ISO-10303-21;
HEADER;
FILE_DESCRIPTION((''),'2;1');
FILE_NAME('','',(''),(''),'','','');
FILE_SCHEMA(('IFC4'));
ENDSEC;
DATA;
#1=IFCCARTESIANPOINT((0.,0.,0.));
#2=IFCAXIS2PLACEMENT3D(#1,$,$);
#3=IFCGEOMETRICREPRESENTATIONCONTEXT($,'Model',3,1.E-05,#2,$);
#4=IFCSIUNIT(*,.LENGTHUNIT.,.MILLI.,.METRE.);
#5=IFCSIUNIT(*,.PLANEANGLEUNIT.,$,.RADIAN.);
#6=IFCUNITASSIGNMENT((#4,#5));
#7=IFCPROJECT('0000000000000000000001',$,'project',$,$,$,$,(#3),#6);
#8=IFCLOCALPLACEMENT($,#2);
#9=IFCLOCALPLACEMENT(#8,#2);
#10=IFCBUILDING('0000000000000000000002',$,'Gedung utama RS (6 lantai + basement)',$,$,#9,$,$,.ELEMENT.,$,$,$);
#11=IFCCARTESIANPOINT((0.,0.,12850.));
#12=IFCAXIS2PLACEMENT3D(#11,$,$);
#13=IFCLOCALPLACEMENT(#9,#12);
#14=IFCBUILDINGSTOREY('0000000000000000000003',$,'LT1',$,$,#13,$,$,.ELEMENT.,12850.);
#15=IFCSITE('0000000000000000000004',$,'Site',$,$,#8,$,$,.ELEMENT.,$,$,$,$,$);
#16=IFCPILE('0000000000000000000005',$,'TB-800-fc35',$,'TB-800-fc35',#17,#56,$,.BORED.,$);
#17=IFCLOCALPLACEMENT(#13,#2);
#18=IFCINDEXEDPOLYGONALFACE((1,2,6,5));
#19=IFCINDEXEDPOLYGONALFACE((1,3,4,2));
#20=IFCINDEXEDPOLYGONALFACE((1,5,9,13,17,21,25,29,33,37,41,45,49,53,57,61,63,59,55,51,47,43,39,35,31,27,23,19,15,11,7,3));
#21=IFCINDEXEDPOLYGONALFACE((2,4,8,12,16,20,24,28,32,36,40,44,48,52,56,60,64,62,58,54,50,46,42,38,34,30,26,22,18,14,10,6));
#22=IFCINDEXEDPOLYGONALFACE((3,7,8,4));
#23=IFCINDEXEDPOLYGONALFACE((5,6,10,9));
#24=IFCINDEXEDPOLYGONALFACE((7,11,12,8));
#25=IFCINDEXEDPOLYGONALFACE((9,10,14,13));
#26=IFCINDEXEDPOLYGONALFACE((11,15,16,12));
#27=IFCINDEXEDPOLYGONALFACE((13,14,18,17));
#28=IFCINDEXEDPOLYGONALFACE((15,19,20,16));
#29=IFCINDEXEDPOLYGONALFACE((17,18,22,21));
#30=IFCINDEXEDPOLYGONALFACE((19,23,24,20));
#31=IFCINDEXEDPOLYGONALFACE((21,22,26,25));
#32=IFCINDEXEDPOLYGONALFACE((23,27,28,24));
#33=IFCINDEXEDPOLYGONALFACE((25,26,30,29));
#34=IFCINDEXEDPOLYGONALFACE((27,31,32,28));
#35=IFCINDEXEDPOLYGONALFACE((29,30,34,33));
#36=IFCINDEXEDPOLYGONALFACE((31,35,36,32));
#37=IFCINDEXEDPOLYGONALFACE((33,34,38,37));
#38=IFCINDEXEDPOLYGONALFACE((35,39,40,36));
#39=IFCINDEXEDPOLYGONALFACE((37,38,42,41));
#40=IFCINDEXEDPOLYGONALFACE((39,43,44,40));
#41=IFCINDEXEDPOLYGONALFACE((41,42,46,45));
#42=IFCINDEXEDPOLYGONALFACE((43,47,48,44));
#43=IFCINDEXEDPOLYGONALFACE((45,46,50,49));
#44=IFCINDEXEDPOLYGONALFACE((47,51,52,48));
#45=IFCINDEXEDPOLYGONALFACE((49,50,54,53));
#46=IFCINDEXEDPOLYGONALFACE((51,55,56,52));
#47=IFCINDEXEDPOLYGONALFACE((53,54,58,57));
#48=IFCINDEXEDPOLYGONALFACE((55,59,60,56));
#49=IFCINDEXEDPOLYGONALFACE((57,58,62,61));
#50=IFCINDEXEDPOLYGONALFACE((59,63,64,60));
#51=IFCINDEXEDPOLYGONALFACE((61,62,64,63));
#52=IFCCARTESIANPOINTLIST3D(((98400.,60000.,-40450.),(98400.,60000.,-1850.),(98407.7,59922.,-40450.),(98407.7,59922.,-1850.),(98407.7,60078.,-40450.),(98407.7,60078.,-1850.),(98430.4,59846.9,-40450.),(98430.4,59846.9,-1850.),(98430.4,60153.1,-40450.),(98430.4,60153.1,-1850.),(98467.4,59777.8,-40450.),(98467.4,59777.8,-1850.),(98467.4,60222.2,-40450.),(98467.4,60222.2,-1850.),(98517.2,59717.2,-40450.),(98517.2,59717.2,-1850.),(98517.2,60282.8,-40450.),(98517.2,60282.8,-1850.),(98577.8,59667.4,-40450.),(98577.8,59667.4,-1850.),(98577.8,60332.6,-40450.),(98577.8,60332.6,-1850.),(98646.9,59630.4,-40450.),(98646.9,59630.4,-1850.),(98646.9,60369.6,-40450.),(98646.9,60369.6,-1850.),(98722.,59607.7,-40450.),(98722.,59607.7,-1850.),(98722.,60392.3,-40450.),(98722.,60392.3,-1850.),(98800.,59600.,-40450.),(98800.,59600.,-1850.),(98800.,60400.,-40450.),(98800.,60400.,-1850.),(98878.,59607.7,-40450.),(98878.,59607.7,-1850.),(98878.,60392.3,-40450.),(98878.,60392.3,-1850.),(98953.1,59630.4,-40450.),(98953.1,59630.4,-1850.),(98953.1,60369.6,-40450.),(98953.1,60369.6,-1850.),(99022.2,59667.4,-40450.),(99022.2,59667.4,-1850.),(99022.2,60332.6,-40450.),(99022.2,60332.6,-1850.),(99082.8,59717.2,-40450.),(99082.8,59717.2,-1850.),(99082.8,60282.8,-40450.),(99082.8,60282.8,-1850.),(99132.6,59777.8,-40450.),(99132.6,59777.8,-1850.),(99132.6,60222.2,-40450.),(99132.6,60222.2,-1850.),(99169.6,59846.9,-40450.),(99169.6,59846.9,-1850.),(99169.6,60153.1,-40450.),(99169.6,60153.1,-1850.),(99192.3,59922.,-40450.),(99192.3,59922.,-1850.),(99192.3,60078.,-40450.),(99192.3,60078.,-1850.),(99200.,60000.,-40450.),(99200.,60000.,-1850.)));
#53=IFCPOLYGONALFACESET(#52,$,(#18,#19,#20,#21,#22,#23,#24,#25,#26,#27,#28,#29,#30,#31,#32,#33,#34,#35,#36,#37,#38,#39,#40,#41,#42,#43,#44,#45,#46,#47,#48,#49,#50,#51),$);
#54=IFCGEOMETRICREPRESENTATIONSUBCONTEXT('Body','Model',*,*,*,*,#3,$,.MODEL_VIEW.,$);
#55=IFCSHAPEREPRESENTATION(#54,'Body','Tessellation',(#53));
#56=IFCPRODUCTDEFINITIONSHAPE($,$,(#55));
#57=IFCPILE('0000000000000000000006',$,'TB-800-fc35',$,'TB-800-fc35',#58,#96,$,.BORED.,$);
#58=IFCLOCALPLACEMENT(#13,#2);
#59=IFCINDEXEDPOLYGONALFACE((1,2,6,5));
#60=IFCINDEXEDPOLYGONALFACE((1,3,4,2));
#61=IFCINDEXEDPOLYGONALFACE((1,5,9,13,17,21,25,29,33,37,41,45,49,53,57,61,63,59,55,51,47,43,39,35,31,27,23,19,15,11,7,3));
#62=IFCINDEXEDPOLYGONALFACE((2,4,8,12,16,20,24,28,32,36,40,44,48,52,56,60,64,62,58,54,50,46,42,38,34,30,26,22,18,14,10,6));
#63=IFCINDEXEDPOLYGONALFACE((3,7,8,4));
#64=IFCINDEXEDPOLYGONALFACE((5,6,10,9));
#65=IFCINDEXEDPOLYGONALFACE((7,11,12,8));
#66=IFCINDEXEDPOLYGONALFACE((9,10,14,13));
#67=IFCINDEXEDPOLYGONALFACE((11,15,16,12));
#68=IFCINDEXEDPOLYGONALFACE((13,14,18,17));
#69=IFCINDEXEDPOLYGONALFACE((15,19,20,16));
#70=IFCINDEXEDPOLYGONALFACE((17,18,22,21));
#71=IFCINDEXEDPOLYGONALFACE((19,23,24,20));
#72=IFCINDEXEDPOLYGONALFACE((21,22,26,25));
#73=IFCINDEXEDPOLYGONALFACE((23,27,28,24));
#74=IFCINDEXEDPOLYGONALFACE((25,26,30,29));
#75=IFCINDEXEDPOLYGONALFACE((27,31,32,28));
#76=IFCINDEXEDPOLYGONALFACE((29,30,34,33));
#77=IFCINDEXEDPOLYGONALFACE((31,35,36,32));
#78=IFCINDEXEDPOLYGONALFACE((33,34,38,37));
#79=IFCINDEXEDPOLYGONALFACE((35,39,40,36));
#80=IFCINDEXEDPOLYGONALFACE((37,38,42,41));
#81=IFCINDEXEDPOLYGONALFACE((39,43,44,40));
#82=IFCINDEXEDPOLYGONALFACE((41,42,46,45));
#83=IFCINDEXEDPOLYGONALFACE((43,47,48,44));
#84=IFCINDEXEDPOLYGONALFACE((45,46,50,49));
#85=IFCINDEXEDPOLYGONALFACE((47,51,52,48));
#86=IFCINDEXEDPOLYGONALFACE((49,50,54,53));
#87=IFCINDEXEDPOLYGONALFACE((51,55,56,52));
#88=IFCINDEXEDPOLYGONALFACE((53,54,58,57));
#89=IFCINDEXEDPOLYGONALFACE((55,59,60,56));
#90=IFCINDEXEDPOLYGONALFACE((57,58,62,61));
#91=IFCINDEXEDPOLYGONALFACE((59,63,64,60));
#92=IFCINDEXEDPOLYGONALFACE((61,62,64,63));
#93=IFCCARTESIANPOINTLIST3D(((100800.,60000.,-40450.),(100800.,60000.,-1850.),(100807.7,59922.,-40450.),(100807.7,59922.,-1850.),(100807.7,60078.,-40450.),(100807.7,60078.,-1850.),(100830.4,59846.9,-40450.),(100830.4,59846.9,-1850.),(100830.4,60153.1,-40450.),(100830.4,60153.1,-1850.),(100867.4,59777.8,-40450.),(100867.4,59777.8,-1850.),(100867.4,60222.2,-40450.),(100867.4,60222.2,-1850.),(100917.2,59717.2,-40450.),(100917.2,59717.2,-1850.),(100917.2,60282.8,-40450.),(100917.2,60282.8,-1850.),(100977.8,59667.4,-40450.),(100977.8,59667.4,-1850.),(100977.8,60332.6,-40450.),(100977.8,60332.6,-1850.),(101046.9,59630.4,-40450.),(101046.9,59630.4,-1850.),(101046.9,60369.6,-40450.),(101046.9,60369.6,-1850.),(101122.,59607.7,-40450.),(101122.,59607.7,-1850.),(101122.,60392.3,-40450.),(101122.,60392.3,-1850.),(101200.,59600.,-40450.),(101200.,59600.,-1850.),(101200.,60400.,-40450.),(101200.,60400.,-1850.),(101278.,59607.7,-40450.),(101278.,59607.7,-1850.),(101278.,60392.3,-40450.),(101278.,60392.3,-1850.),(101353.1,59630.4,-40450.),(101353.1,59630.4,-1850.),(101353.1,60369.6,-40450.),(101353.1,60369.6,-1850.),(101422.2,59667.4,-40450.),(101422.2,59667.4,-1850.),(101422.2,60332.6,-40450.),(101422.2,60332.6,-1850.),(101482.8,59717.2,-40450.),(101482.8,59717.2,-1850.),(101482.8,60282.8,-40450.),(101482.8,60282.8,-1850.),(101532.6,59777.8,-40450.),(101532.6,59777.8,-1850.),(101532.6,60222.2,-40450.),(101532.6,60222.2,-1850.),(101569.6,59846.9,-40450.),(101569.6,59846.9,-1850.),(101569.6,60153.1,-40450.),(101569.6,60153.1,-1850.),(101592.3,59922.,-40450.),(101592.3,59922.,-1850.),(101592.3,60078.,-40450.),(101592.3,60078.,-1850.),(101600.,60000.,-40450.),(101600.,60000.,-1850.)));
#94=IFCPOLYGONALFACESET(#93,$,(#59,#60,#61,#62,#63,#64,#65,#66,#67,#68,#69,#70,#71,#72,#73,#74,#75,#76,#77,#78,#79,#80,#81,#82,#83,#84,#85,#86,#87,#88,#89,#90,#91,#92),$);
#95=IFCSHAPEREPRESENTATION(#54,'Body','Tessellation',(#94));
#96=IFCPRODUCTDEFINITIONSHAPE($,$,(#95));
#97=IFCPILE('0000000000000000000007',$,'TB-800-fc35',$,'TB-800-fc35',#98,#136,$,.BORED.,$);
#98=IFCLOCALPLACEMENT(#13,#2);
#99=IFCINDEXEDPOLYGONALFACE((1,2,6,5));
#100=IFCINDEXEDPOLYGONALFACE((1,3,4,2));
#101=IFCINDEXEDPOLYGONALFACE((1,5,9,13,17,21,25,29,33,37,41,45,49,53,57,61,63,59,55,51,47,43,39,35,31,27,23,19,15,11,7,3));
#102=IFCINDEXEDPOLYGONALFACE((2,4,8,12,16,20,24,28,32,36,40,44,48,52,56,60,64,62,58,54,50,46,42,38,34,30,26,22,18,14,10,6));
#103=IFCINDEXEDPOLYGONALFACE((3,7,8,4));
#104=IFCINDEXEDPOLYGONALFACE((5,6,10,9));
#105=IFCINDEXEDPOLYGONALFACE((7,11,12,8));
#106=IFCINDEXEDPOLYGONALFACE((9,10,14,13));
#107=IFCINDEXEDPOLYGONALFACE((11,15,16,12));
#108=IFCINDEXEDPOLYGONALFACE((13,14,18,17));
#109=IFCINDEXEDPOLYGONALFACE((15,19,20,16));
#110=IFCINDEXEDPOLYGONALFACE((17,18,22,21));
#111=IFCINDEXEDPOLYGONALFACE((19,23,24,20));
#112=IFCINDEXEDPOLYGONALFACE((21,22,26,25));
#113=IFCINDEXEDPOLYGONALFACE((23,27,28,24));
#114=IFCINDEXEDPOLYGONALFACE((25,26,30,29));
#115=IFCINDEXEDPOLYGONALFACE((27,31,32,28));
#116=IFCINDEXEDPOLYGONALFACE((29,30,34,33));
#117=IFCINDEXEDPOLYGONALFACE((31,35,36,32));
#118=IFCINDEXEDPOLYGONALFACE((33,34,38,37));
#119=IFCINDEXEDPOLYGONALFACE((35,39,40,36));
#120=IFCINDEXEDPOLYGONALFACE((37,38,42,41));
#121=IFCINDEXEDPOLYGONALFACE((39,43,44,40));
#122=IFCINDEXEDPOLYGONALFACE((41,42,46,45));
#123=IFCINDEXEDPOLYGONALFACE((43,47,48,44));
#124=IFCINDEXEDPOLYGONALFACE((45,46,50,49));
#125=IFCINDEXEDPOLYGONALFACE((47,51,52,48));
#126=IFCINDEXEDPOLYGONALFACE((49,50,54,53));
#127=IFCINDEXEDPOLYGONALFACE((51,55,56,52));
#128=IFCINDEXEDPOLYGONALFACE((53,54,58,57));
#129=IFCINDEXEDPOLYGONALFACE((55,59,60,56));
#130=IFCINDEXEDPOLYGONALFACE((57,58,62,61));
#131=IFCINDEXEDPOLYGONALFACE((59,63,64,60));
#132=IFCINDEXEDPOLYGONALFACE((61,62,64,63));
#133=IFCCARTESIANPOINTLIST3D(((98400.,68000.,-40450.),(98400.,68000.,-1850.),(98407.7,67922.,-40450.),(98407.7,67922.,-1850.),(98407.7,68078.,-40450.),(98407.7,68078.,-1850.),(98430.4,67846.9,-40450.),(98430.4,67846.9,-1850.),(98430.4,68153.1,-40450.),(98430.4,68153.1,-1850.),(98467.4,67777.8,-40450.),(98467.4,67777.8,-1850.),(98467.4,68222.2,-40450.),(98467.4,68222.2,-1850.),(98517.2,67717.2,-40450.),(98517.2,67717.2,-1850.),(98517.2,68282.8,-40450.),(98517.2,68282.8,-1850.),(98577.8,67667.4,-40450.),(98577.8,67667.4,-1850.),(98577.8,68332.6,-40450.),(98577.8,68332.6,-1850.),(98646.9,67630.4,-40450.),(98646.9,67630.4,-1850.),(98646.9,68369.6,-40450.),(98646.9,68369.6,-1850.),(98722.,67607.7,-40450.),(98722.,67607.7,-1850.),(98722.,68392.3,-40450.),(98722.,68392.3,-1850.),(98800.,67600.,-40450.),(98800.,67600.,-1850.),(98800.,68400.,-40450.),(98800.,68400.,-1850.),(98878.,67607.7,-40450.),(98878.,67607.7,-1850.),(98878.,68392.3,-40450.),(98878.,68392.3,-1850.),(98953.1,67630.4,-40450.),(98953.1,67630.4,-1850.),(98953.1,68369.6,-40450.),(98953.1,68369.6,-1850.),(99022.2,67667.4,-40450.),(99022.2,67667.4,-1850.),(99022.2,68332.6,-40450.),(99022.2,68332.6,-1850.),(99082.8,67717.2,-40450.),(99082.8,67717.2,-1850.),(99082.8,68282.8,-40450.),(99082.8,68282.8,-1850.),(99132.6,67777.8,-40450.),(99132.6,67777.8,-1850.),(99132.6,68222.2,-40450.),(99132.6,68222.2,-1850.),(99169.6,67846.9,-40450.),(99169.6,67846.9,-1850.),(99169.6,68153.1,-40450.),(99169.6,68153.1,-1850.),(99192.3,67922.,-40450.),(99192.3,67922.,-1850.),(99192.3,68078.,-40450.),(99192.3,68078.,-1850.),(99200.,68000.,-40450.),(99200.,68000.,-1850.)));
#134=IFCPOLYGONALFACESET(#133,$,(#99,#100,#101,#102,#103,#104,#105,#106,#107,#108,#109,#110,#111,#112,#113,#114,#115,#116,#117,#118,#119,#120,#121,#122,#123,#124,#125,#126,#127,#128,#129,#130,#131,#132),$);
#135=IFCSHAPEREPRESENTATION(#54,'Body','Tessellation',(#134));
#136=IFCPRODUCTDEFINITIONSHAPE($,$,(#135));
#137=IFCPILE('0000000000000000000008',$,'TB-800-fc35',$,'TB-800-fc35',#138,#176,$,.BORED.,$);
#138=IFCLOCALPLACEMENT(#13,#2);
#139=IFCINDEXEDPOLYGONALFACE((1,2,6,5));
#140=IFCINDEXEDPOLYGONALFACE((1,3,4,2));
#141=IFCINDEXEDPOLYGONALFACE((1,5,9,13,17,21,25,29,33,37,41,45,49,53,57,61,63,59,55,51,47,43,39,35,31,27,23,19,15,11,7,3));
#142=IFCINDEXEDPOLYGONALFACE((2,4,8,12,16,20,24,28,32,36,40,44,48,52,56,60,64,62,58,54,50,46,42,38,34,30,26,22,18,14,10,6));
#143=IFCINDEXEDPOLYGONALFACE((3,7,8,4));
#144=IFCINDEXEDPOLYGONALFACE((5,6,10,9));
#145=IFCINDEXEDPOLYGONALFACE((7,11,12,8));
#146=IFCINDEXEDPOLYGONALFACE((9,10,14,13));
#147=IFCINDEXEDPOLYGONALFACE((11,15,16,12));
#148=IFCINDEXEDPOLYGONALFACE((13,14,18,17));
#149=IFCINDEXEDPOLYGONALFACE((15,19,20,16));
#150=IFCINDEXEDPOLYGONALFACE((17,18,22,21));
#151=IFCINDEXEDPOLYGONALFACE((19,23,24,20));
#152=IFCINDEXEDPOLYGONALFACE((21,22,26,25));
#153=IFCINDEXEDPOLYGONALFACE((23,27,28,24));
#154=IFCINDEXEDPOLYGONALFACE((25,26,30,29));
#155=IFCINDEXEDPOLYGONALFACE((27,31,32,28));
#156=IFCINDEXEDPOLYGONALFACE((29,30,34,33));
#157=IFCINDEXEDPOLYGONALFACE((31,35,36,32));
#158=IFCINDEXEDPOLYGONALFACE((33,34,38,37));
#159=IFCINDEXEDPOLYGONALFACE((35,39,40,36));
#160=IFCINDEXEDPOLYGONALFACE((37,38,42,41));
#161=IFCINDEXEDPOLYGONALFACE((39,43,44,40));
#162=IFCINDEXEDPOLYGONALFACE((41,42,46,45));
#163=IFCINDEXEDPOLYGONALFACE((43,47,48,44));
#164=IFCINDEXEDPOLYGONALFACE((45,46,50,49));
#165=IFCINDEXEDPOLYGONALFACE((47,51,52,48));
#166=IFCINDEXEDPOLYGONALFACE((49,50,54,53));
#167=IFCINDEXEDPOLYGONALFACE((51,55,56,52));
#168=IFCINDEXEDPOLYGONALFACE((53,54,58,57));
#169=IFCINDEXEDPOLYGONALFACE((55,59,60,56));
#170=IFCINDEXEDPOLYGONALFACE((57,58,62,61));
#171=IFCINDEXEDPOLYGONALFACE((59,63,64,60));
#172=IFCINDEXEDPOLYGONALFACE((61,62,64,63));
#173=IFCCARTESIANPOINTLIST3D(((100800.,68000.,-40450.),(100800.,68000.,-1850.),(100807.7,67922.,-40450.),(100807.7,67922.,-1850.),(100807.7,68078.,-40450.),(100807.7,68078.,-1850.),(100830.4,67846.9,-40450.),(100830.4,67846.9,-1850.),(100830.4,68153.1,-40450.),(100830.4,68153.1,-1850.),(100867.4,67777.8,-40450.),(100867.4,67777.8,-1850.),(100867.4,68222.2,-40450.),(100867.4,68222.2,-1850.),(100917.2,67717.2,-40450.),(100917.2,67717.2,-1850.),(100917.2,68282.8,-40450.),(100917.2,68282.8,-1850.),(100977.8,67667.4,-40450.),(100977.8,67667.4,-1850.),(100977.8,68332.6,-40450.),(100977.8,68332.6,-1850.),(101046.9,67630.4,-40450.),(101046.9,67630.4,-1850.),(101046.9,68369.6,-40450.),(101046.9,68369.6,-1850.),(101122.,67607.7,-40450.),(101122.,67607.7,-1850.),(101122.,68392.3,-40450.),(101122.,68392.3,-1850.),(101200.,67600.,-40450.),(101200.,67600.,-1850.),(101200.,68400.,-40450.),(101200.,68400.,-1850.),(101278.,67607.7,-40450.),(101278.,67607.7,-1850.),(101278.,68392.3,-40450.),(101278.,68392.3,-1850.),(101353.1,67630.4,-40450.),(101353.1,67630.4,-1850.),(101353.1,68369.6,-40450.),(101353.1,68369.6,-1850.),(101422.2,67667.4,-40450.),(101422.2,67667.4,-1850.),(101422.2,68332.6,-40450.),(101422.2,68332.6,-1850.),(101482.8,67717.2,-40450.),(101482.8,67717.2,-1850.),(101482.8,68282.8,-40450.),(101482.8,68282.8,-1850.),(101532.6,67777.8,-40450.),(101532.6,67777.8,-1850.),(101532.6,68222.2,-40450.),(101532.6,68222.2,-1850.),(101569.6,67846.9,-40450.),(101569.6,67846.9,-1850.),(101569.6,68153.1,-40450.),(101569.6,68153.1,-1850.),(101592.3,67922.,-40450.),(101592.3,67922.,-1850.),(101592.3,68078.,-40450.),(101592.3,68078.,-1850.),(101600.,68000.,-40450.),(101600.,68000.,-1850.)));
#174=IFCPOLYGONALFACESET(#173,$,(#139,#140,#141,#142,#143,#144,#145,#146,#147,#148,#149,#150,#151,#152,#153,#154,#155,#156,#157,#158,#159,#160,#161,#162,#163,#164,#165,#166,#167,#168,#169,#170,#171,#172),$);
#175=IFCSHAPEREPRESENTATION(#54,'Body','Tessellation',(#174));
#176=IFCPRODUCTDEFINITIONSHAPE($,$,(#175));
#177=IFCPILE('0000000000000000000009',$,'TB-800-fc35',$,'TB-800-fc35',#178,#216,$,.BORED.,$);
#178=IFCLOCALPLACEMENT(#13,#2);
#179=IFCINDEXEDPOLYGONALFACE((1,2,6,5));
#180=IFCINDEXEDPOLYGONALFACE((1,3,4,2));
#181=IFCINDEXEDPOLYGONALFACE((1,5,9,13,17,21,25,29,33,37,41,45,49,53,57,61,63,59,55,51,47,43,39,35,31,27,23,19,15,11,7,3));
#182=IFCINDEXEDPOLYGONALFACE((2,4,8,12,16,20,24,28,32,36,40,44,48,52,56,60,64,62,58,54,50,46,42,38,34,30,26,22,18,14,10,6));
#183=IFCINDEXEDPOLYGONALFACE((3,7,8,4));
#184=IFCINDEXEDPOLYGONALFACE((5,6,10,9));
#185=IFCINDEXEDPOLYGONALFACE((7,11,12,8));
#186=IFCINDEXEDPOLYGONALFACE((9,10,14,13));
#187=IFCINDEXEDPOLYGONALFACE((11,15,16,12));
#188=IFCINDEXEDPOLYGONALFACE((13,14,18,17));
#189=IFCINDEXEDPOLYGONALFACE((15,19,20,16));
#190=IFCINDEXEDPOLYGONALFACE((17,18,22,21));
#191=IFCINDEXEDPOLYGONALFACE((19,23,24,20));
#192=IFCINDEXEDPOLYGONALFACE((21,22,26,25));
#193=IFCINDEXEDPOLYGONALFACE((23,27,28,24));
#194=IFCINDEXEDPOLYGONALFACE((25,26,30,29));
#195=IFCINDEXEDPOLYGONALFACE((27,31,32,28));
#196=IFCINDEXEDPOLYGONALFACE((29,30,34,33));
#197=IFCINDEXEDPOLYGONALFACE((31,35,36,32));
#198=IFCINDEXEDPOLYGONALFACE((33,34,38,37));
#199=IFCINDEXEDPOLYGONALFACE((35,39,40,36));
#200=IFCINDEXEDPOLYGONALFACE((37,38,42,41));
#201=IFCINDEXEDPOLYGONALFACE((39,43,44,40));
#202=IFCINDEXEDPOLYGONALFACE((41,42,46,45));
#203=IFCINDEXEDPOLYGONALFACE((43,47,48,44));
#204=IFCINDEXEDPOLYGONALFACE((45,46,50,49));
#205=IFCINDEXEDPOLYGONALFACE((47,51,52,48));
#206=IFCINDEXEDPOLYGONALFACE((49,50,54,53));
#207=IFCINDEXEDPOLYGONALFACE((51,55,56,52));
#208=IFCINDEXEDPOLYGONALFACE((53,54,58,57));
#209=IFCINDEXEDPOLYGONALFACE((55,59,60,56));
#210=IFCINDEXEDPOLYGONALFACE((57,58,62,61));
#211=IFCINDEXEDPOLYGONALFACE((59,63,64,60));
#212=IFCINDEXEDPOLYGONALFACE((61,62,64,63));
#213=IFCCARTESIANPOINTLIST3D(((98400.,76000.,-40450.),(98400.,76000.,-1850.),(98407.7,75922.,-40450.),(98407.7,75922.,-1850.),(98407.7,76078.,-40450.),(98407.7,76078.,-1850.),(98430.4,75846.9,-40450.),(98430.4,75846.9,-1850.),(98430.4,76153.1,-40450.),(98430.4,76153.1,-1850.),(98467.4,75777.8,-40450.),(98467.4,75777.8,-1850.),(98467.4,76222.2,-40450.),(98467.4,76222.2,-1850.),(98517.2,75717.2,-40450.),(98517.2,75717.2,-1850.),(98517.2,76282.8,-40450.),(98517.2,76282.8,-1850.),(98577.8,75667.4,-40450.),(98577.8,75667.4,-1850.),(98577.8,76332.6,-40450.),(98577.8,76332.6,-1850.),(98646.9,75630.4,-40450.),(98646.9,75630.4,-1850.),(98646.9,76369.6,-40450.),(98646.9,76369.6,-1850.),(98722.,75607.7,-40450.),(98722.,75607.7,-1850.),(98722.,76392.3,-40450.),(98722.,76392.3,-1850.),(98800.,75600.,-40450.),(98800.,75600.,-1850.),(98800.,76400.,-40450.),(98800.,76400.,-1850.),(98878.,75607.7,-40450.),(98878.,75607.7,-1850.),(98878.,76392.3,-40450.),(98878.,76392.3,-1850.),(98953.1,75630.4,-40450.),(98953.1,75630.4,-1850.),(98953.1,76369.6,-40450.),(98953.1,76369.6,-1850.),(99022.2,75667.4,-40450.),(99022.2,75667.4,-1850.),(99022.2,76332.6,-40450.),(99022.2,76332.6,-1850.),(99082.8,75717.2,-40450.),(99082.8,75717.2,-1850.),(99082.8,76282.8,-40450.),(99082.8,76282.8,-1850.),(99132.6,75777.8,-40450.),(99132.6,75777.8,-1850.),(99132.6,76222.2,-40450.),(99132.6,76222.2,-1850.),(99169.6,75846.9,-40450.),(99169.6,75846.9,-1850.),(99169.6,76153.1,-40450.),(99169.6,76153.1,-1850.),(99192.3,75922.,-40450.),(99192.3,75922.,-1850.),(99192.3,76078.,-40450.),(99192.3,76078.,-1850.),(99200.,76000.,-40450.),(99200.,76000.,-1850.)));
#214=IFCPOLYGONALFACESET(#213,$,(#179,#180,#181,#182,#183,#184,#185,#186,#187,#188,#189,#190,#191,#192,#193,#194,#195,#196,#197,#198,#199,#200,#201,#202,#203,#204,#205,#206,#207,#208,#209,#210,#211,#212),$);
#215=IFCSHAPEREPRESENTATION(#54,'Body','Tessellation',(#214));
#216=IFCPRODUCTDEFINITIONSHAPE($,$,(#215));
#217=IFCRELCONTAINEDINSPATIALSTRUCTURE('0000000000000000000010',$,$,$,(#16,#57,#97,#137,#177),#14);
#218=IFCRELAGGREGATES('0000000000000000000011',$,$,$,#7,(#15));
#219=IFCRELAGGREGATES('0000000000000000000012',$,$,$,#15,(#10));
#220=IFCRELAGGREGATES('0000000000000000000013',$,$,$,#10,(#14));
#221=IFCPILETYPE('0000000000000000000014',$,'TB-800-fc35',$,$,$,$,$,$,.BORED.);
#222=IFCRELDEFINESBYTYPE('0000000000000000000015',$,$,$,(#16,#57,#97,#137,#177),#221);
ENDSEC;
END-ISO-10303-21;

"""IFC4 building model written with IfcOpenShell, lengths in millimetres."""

from ifc_helpers import new_model, si_unit, frame, origin, origin_2d, place, context, subcontext, project, spatial, circle, extrude, material_profile, profile_set, profile_usage, type_object, element, save


model = new_model("IFC4")

# Units and contexts
model_context = context("Model", 3, precision=1e-05, world=origin())
body_context = subcontext(model_context, "Body", "Model", "MODEL_VIEW")
ifc_project = project(units=[si_unit("LENGTHUNIT", "METRE", prefix="MILLI"), si_unit("PLANEANGLEUNIT", "RADIAN")], contexts=[model_context])

# Site, building, storey
site_placement = place(None, origin())
site = spatial("IfcSite", under=ifc_project, at=site_placement, Name="Site", CompositionType="ELEMENT")
building_placement = place(site_placement, origin())
building = spatial("IfcBuilding", under=site, at=building_placement, Name="Gedung utama RS (6 lantai + basement)", CompositionType="ELEMENT")
storey_placement = place(building_placement, frame((0.0, 0.0, 12850.0)))
storey = spatial("IfcBuildingStorey", under=building, at=storey_placement, Name="LT1", CompositionType="ELEMENT", Elevation=12850.0)

# Piles
ifc_material_profile = material_profile(None, circle(Radius=400.0, at=origin_2d()), Name="TB-800-fc35")
ifc_profile_set = profile_set([ifc_material_profile], Name="TB-800-fc35")
ifc_profile_usage = profile_usage(ifc_profile_set, cardinal=5)
pile_type = type_object("IfcPileType", Name="TB-800-fc35", PredefinedType="BORED", material=ifc_profile_set)
for number, where, z_axis, x_axis, name in (
    (1, (98800.0, 60000.0, -40450.0), (0.0, 0.0, 1.0), (1.0, 0.0, 0.0), "TB-800-fc35"),
    (2, (101200.0, 60000.0, -40450.0), (0.0, 0.0, 1.0), (1.0, 0.0, 0.0), "TB-800-fc35"),
    (3, (98800.0, 68000.0, -40450.0), (0.0, 0.0, 1.0), (1.0, 0.0, 0.0), "TB-800-fc35"),
    (4, (101200.0, 68000.0, -40450.0), (0.0, 0.0, 1.0), (1.0, 0.0, 0.0), "TB-800-fc35"),
    (5, (98800.0, 76000.0, -40450.0), (0.0, 0.0, 1.0), (1.0, 0.0, 0.0), "TB-800-fc35"),
):
    element("IfcPile", number, at=place(storey_placement, frame(where, z_axis=z_axis, x_axis=x_axis)), inside=storey, type_object=pile_type, material=ifc_profile_usage, Name=name, ObjectType="TB-800-fc35", PredefinedType="BORED", context=body_context, shape_type="SweptSolid", body=[
        extrude(circle(Radius=400.0, at=origin_2d()), origin(), (0.0, 0.0, 1.0), 38600.0),
    ])

save(model, "model.ifc")
